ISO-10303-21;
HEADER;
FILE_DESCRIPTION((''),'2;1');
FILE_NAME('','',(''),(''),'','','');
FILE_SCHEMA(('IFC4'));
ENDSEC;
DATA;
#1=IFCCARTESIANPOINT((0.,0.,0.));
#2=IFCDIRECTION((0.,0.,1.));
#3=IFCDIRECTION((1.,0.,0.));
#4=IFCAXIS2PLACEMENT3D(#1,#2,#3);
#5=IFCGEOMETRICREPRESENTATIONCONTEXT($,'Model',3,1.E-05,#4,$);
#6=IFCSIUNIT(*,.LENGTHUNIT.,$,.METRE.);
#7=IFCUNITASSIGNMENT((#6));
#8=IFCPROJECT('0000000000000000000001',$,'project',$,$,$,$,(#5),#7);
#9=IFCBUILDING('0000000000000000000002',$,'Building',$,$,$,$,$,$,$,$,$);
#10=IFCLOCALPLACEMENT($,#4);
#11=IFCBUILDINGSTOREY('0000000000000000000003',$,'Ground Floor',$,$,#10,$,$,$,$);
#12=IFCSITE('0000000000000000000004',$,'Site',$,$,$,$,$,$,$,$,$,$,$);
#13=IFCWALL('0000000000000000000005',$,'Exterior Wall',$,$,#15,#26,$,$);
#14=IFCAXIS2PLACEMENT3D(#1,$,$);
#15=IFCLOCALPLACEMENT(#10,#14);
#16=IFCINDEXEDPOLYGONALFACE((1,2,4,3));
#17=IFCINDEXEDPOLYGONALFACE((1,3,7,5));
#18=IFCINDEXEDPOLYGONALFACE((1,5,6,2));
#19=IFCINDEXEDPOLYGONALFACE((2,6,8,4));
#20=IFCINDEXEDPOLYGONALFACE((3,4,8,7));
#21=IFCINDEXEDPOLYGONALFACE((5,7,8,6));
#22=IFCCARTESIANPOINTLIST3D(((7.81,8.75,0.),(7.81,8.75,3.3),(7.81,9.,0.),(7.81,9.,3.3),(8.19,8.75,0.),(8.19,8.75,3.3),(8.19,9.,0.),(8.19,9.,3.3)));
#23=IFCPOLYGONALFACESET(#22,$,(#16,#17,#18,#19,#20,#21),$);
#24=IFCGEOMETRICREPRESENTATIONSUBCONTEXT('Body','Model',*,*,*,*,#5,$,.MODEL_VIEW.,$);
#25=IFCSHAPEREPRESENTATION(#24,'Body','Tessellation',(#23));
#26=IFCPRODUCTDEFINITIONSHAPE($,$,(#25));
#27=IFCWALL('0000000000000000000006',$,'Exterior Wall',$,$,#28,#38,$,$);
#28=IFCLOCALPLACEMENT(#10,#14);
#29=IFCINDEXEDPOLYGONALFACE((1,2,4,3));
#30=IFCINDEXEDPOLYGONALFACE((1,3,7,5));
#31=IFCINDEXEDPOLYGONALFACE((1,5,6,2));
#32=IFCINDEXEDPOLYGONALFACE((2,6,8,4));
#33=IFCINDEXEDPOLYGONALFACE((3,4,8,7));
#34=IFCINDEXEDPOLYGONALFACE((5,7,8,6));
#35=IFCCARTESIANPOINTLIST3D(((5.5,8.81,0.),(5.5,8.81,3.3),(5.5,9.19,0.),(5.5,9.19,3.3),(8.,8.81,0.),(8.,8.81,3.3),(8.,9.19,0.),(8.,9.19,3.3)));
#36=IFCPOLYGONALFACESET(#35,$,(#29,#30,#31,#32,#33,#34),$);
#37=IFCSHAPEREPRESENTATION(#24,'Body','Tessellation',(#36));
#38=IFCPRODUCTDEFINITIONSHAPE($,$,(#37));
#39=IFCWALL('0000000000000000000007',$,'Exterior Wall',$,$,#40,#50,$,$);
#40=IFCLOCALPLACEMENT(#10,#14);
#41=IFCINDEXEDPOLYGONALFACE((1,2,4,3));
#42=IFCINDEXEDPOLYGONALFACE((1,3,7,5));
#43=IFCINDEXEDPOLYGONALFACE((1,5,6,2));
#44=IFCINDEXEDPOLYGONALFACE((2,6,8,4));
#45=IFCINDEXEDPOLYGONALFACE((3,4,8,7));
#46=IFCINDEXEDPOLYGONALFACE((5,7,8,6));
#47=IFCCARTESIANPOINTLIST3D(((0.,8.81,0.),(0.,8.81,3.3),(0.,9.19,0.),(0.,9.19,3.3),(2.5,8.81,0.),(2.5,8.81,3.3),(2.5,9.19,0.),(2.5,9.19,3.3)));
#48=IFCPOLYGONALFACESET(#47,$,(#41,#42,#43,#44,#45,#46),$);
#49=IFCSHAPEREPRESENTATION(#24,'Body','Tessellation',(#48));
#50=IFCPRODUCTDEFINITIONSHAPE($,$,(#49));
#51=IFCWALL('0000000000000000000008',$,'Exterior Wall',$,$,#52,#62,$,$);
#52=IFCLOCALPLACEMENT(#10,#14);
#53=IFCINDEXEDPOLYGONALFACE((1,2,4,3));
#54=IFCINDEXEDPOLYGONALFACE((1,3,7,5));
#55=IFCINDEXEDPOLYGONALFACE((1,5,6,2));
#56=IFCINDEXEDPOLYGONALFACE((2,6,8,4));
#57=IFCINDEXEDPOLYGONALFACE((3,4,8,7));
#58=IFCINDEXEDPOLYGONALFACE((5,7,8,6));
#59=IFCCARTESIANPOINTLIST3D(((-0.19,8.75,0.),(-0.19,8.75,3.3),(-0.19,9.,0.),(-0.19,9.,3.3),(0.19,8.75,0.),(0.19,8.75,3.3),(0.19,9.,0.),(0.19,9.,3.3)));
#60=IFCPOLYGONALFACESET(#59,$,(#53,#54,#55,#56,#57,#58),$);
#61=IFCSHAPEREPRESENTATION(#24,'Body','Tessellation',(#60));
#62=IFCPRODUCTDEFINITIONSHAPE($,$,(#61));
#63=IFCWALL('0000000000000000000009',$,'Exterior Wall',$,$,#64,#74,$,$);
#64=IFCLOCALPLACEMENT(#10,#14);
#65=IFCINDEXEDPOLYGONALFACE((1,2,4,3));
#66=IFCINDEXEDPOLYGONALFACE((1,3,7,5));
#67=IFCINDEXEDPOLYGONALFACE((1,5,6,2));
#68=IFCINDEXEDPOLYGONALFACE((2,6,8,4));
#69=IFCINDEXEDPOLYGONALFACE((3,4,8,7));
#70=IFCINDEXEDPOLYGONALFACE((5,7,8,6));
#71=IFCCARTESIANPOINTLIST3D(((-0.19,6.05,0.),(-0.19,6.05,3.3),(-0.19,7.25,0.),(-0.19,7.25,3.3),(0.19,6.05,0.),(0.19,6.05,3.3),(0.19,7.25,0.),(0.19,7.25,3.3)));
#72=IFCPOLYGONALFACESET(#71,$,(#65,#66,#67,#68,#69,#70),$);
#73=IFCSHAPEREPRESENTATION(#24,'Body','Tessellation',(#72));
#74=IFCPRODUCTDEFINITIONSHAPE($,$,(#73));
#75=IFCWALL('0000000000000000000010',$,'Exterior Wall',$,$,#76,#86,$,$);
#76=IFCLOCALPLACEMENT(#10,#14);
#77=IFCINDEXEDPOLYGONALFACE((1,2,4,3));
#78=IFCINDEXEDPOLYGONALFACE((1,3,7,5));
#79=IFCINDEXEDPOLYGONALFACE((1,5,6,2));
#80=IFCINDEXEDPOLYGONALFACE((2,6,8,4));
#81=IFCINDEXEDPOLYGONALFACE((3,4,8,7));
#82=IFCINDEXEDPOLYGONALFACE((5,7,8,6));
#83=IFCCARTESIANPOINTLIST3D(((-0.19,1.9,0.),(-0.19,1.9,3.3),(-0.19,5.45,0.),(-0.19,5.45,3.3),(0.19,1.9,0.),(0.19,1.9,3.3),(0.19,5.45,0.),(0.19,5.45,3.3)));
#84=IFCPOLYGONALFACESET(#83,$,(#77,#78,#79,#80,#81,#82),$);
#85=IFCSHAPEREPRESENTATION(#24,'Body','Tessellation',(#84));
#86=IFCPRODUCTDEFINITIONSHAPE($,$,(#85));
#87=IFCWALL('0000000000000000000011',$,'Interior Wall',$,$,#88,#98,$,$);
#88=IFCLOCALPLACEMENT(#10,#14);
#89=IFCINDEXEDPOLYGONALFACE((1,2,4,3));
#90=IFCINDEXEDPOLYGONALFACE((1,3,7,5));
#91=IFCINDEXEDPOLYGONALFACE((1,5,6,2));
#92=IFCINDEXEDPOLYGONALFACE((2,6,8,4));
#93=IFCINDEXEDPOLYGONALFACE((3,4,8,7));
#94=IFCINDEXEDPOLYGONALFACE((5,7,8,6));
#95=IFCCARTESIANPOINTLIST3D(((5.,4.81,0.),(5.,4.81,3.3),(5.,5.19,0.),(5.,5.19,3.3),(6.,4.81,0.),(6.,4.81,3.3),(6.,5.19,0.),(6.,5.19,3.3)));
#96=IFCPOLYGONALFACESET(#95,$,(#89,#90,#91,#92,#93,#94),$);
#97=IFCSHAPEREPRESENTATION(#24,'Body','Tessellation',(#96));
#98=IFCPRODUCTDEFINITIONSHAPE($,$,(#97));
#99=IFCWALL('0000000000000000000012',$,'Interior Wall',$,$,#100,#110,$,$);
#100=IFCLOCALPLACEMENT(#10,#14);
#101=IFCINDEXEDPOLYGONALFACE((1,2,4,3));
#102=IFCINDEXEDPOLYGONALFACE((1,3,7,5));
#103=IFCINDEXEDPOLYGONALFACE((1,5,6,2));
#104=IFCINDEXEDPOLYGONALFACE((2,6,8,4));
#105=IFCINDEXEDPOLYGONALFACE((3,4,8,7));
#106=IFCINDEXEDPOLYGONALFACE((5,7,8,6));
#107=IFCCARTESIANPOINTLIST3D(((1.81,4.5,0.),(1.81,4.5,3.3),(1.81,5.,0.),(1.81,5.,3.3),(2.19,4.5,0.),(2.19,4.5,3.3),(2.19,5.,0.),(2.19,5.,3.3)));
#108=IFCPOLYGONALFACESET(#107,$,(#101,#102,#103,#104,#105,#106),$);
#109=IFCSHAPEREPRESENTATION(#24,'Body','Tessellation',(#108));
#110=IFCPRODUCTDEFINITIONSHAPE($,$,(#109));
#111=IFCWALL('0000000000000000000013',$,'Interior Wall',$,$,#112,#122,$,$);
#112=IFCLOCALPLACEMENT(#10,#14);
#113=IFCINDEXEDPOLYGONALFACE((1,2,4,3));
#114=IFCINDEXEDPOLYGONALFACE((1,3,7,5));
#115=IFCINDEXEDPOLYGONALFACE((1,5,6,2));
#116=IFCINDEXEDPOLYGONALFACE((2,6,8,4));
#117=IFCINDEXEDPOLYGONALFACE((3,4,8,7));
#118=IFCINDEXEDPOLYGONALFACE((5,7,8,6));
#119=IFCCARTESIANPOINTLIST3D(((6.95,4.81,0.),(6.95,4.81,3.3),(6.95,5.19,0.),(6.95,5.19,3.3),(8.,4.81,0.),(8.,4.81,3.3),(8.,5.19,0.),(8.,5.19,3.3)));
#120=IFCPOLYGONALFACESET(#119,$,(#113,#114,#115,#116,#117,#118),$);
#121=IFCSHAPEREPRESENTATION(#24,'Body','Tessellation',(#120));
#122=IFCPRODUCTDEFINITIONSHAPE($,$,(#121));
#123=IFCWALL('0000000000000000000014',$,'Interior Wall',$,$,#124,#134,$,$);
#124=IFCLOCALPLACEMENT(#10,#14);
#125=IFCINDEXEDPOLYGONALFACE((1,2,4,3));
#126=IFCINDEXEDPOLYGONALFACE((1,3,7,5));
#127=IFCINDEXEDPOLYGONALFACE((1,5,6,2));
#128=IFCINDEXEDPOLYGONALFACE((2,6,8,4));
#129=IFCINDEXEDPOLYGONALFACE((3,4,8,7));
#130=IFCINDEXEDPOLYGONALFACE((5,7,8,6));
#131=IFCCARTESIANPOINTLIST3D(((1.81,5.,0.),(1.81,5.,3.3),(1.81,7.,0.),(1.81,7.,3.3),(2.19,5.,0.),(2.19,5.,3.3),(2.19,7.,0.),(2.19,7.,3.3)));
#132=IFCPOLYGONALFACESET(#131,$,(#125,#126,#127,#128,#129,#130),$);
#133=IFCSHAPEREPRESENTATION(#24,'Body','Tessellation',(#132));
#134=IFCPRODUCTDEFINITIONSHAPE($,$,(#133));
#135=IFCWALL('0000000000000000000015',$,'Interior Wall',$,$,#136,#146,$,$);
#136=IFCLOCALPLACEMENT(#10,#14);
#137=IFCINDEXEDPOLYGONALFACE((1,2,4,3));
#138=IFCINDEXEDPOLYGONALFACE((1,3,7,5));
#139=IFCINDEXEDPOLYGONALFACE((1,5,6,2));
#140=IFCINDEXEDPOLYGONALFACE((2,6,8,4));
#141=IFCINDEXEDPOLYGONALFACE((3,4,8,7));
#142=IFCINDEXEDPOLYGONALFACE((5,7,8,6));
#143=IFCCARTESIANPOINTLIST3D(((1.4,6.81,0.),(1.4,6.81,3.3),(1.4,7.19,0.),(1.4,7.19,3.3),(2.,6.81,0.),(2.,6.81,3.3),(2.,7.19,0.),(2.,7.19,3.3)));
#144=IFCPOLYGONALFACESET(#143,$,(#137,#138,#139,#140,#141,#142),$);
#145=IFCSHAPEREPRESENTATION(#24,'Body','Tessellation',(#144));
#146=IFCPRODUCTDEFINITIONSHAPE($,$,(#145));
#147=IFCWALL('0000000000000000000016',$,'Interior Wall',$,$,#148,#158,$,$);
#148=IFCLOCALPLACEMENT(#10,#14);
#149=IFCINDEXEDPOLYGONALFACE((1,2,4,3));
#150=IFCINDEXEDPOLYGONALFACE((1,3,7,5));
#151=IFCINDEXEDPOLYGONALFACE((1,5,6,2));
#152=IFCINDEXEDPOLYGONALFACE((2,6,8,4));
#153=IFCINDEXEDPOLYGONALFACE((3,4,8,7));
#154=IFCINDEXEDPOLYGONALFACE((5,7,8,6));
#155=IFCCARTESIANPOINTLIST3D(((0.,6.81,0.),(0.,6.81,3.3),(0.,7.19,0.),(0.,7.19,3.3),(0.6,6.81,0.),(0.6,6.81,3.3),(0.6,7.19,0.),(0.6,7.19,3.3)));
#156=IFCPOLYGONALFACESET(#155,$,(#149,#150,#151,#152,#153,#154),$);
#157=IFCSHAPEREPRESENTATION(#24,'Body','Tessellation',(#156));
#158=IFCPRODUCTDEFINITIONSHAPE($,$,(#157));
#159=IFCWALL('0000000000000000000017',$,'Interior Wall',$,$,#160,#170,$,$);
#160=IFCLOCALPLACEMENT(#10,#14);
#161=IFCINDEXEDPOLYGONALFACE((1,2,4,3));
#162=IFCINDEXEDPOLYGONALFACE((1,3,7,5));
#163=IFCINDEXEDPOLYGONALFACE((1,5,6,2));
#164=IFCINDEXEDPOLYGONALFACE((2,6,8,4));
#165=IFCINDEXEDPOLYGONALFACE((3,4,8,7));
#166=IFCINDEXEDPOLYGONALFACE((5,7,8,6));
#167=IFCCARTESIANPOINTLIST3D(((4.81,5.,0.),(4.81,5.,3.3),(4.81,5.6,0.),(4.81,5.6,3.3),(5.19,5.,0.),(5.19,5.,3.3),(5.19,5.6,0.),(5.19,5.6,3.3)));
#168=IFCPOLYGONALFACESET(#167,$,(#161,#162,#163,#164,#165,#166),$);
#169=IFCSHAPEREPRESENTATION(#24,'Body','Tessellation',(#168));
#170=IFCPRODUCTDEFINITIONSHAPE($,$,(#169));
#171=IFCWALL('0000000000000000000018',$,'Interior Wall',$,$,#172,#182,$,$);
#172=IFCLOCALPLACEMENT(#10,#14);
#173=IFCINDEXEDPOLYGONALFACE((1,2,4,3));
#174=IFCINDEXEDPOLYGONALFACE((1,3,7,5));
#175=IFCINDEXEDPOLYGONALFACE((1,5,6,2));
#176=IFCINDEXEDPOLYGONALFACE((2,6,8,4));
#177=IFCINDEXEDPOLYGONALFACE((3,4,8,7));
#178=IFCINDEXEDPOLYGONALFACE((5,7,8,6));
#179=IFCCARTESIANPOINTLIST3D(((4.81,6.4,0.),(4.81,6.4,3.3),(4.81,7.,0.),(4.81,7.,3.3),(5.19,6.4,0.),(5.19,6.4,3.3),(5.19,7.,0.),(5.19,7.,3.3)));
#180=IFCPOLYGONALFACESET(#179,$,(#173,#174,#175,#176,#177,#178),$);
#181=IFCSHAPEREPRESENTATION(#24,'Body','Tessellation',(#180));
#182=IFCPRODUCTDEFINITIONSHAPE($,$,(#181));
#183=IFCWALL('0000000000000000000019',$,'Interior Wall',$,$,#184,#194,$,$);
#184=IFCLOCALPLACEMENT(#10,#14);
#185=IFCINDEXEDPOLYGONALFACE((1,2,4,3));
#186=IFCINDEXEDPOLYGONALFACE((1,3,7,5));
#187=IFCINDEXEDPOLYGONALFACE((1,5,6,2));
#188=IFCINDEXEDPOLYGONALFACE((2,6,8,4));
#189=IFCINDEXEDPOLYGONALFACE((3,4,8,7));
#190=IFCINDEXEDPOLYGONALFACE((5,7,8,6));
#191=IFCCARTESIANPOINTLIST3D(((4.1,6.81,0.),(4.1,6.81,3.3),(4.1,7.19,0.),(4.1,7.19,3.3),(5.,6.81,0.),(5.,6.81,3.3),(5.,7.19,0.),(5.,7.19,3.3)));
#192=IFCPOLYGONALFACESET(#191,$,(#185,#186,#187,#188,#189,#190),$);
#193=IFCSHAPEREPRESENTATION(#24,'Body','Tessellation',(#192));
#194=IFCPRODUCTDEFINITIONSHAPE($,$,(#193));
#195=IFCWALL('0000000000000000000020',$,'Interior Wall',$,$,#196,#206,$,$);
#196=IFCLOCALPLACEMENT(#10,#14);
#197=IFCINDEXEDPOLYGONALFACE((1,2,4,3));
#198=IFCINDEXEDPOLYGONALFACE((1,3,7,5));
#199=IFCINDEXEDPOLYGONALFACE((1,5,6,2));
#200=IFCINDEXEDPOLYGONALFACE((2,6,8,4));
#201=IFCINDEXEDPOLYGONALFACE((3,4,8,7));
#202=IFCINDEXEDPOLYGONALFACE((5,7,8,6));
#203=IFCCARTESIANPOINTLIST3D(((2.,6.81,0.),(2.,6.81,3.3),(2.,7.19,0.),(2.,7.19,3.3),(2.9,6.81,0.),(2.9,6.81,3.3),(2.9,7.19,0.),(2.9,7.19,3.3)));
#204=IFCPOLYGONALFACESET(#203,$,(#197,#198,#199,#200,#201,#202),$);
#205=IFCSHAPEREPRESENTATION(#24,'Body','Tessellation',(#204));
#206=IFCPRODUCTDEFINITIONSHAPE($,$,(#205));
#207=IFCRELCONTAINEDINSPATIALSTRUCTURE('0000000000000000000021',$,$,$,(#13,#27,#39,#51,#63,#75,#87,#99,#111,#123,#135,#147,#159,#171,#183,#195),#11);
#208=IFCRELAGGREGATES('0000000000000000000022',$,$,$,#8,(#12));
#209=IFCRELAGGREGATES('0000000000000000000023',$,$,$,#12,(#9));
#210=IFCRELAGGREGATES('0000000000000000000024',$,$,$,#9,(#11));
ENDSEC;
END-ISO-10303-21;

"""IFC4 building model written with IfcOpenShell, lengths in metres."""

from ifc_helpers import new_model, si_unit, frame, origin_with_axes, place, context, subcontext, project, spatial, indexed_curve, outline, extrude, element, save


model = new_model("IFC4")

# Units and contexts
model_context = context("Model", 3, precision=1e-05, world=origin_with_axes())
body_context = subcontext(model_context, "Body", "Model", "MODEL_VIEW")
ifc_project = project(units=[si_unit("LENGTHUNIT", "METRE")], contexts=[model_context])

# Site, building, storey
site = spatial("IfcSite", under=ifc_project, Name="Site")
building = spatial("IfcBuilding", under=site, Name="Building")
storey_placement = place(None, origin_with_axes())
storey = spatial("IfcBuildingStorey", under=building, at=storey_placement, Name="Ground Floor")

# Walls
wall_1_placement = place(storey_placement, frame((8.0, 8.75, 0.0), z_axis=(0.0, 0.0, 1.0), x_axis=(0.0, 1.0, 0.0)))
element("IfcWall", 1, at=wall_1_placement, inside=storey, Name="Exterior Wall", context=body_context, shape_type="SweptSolid", body=[
    extrude(outline(indexed_curve([(0.0, 0.0), (0.0, 0.38), (0.25, 0.38), (0.25, 0.0), (0.0, 0.0)], self_intersect=False)), frame((0.0, -0.19, 0.0), z_axis=(0.0, 0.0, 1.0), x_axis=(1.0, 0.0, 0.0)), (0.0, 0.0, 1.0), 3.3),
])
for number, where, z_axis, x_axis, name in (
    (2, (8.0, 9.0, 0.0), (0.0, 0.0, 1.0), (-1.0, 0.0, 0.0), "Exterior Wall"),
    (3, (2.5, 9.0, 0.0), (0.0, 0.0, 1.0), (-1.0, 0.0, 0.0), "Exterior Wall"),
):
    element("IfcWall", number, at=place(storey_placement, frame(where, z_axis=z_axis, x_axis=x_axis)), inside=storey, Name=name, context=body_context, shape_type="SweptSolid", body=[
        extrude(outline(indexed_curve([(0.0, 0.0), (0.0, 0.38), (2.5, 0.38), (2.5, 0.0), (0.0, 0.0)], self_intersect=False)), frame((0.0, -0.19, 0.0), z_axis=(0.0, 0.0, 1.0), x_axis=(1.0, 0.0, 0.0)), (0.0, 0.0, 1.0), 3.3),
    ])
wall_2_placement = place(storey_placement, frame((0.0, 9.0, 0.0), z_axis=(0.0, 0.0, 1.0), x_axis=(0.0, -1.0, 0.0)))
element("IfcWall", 4, at=wall_2_placement, inside=storey, Name="Exterior Wall", context=body_context, shape_type="SweptSolid", body=[
    extrude(outline(indexed_curve([(0.0, 0.0), (0.0, 0.38), (0.25, 0.38), (0.25, 0.0), (0.0, 0.0)], self_intersect=False)), frame((0.0, -0.19, 0.0), z_axis=(0.0, 0.0, 1.0), x_axis=(1.0, 0.0, 0.0)), (0.0, 0.0, 1.0), 3.3),
])
wall_3_placement = place(storey_placement, frame((0.0, 7.25, 0.0), z_axis=(0.0, 0.0, 1.0), x_axis=(0.0, -1.0, 0.0)))
element("IfcWall", 5, at=wall_3_placement, inside=storey, Name="Exterior Wall", context=body_context, shape_type="SweptSolid", body=[
    extrude(outline(indexed_curve([(0.0, 0.0), (0.0, 0.38), (1.2, 0.38), (1.2, 0.0), (0.0, 0.0)], self_intersect=False)), frame((0.0, -0.19, 0.0), z_axis=(0.0, 0.0, 1.0), x_axis=(1.0, 0.0, 0.0)), (0.0, 0.0, 1.0), 3.3),
])
wall_4_placement = place(storey_placement, frame((0.0, 5.45, 0.0), z_axis=(0.0, 0.0, 1.0), x_axis=(0.0, -1.0, 0.0)))
element("IfcWall", 6, at=wall_4_placement, inside=storey, Name="Exterior Wall", context=body_context, shape_type="SweptSolid", body=[
    extrude(outline(indexed_curve([(0.0, 0.0), (0.0, 0.38), (3.55, 0.38), (3.55, 0.0), (0.0, 0.0)], self_intersect=False)), frame((0.0, -0.19, 0.0), z_axis=(0.0, 0.0, 1.0), x_axis=(1.0, 0.0, 0.0)), (0.0, 0.0, 1.0), 3.3),
])
wall_5_placement = place(storey_placement, frame((6.0, 5.0, 0.0), z_axis=(0.0, 0.0, 1.0), x_axis=(-1.0, 0.0, 0.0)))
element("IfcWall", 7, at=wall_5_placement, inside=storey, Name="Interior Wall", context=body_context, shape_type="SweptSolid", body=[
    extrude(outline(indexed_curve([(0.0, 0.0), (0.0, 0.38), (1.0, 0.38), (1.0, 0.0), (0.0, 0.0)], self_intersect=False)), frame((0.0, -0.19, 0.0), z_axis=(0.0, 0.0, 1.0), x_axis=(1.0, 0.0, 0.0)), (0.0, 0.0, 1.0), 3.3),
])
wall_6_placement = place(storey_placement, frame((2.0, 5.0, 0.0), z_axis=(0.0, 0.0, 1.0), x_axis=(0.0, -1.0, 0.0)))
element("IfcWall", 8, at=wall_6_placement, inside=storey, Name="Interior Wall", context=body_context, shape_type="SweptSolid", body=[
    extrude(outline(indexed_curve([(0.0, 0.0), (0.0, 0.38), (0.5, 0.38), (0.5, 0.0), (0.0, 0.0)], self_intersect=False)), frame((0.0, -0.19, 0.0), z_axis=(0.0, 0.0, 1.0), x_axis=(1.0, 0.0, 0.0)), (0.0, 0.0, 1.0), 3.3),
])
wall_7_placement = place(storey_placement, frame((8.0, 5.0, 0.0), z_axis=(0.0, 0.0, 1.0), x_axis=(-1.0, 0.0, 0.0)))
element("IfcWall", 9, at=wall_7_placement, inside=storey, Name="Interior Wall", context=body_context, shape_type="SweptSolid", body=[
    extrude(outline(indexed_curve([(0.0, 0.0), (0.0, 0.38), (1.05, 0.38), (1.05, 0.0), (0.0, 0.0)], self_intersect=False)), frame((0.0, -0.19, 0.0), z_axis=(0.0, 0.0, 1.0), x_axis=(1.0, 0.0, 0.0)), (0.0, 0.0, 1.0), 3.3),
])
wall_8_placement = place(storey_placement, frame((2.0, 5.0, 0.0), z_axis=(0.0, 0.0, 1.0), x_axis=(0.0, 1.0, 0.0)))
element("IfcWall", 10, at=wall_8_placement, inside=storey, Name="Interior Wall", context=body_context, shape_type="SweptSolid", body=[
    extrude(outline(indexed_curve([(0.0, 0.0), (0.0, 0.38), (2.0, 0.38), (2.0, 0.0), (0.0, 0.0)], self_intersect=False)), frame((0.0, -0.19, 0.0), z_axis=(0.0, 0.0, 1.0), x_axis=(1.0, 0.0, 0.0)), (0.0, 0.0, 1.0), 3.3),
])
for number, where, z_axis, x_axis, name in (
    (11, (2.0, 7.0, 0.0), (0.0, 0.0, 1.0), (-1.0, 0.0, 0.0), "Interior Wall"),
    (12, (0.6, 7.0, 0.0), (0.0, 0.0, 1.0), (-1.0, 0.0, 0.0), "Interior Wall"),
):
    element("IfcWall", number, at=place(storey_placement, frame(where, z_axis=z_axis, x_axis=x_axis)), inside=storey, Name=name, context=body_context, shape_type="SweptSolid", body=[
        extrude(outline(indexed_curve([(0.0, 0.0), (0.0, 0.38), (0.6, 0.38), (0.6, 0.0), (0.0, 0.0)], self_intersect=False)), frame((0.0, -0.19, 0.0), z_axis=(0.0, 0.0, 1.0), x_axis=(1.0, 0.0, 0.0)), (0.0, 0.0, 1.0), 3.3),
    ])
for number, where, z_axis, x_axis, name in (
    (13, (5.0, 5.0, 0.0), (0.0, 0.0, 1.0), (0.0, 1.0, 0.0), "Interior Wall"),
    (14, (5.0, 6.4, 0.0), (0.0, 0.0, 1.0), (0.0, 1.0, 0.0), "Interior Wall"),
):
    element("IfcWall", number, at=place(storey_placement, frame(where, z_axis=z_axis, x_axis=x_axis)), inside=storey, Name=name, context=body_context, shape_type="SweptSolid", body=[
        extrude(outline(indexed_curve([(0.0, 0.0), (0.0, 0.38), (0.6, 0.38), (0.6, 0.0), (0.0, 0.0)], self_intersect=False)), frame((0.0, -0.19, 0.0), z_axis=(0.0, 0.0, 1.0), x_axis=(1.0, 0.0, 0.0)), (0.0, 0.0, 1.0), 3.3),
    ])
wall_9_placement = place(storey_placement, frame((5.0, 7.0, 0.0), z_axis=(0.0, 0.0, 1.0), x_axis=(-1.0, 0.0, 0.0)))
element("IfcWall", 15, at=wall_9_placement, inside=storey, Name="Interior Wall", context=body_context, shape_type="SweptSolid", body=[
    extrude(outline(indexed_curve([(0.0, 0.0), (0.0, 0.38), (0.9, 0.38), (0.9, 0.0), (0.0, 0.0)], self_intersect=False)), frame((0.0, -0.19, 0.0), z_axis=(0.0, 0.0, 1.0), x_axis=(1.0, 0.0, 0.0)), (0.0, 0.0, 1.0), 3.3),
])
wall_10_placement = place(storey_placement, frame((2.9, 7.0, 0.0), z_axis=(0.0, 0.0, 1.0), x_axis=(-1.0, 0.0, 0.0)))
element("IfcWall", 16, at=wall_10_placement, inside=storey, Name="Interior Wall", context=body_context, shape_type="SweptSolid", body=[
    extrude(outline(indexed_curve([(0.0, 0.0), (0.0, 0.38), (0.9, 0.38), (0.9, 0.0), (0.0, 0.0)], self_intersect=False)), frame((0.0, -0.19, 0.0), z_axis=(0.0, 0.0, 1.0), x_axis=(1.0, 0.0, 0.0)), (0.0, 0.0, 1.0), 3.3),
])

save(model, "model.ifc")
